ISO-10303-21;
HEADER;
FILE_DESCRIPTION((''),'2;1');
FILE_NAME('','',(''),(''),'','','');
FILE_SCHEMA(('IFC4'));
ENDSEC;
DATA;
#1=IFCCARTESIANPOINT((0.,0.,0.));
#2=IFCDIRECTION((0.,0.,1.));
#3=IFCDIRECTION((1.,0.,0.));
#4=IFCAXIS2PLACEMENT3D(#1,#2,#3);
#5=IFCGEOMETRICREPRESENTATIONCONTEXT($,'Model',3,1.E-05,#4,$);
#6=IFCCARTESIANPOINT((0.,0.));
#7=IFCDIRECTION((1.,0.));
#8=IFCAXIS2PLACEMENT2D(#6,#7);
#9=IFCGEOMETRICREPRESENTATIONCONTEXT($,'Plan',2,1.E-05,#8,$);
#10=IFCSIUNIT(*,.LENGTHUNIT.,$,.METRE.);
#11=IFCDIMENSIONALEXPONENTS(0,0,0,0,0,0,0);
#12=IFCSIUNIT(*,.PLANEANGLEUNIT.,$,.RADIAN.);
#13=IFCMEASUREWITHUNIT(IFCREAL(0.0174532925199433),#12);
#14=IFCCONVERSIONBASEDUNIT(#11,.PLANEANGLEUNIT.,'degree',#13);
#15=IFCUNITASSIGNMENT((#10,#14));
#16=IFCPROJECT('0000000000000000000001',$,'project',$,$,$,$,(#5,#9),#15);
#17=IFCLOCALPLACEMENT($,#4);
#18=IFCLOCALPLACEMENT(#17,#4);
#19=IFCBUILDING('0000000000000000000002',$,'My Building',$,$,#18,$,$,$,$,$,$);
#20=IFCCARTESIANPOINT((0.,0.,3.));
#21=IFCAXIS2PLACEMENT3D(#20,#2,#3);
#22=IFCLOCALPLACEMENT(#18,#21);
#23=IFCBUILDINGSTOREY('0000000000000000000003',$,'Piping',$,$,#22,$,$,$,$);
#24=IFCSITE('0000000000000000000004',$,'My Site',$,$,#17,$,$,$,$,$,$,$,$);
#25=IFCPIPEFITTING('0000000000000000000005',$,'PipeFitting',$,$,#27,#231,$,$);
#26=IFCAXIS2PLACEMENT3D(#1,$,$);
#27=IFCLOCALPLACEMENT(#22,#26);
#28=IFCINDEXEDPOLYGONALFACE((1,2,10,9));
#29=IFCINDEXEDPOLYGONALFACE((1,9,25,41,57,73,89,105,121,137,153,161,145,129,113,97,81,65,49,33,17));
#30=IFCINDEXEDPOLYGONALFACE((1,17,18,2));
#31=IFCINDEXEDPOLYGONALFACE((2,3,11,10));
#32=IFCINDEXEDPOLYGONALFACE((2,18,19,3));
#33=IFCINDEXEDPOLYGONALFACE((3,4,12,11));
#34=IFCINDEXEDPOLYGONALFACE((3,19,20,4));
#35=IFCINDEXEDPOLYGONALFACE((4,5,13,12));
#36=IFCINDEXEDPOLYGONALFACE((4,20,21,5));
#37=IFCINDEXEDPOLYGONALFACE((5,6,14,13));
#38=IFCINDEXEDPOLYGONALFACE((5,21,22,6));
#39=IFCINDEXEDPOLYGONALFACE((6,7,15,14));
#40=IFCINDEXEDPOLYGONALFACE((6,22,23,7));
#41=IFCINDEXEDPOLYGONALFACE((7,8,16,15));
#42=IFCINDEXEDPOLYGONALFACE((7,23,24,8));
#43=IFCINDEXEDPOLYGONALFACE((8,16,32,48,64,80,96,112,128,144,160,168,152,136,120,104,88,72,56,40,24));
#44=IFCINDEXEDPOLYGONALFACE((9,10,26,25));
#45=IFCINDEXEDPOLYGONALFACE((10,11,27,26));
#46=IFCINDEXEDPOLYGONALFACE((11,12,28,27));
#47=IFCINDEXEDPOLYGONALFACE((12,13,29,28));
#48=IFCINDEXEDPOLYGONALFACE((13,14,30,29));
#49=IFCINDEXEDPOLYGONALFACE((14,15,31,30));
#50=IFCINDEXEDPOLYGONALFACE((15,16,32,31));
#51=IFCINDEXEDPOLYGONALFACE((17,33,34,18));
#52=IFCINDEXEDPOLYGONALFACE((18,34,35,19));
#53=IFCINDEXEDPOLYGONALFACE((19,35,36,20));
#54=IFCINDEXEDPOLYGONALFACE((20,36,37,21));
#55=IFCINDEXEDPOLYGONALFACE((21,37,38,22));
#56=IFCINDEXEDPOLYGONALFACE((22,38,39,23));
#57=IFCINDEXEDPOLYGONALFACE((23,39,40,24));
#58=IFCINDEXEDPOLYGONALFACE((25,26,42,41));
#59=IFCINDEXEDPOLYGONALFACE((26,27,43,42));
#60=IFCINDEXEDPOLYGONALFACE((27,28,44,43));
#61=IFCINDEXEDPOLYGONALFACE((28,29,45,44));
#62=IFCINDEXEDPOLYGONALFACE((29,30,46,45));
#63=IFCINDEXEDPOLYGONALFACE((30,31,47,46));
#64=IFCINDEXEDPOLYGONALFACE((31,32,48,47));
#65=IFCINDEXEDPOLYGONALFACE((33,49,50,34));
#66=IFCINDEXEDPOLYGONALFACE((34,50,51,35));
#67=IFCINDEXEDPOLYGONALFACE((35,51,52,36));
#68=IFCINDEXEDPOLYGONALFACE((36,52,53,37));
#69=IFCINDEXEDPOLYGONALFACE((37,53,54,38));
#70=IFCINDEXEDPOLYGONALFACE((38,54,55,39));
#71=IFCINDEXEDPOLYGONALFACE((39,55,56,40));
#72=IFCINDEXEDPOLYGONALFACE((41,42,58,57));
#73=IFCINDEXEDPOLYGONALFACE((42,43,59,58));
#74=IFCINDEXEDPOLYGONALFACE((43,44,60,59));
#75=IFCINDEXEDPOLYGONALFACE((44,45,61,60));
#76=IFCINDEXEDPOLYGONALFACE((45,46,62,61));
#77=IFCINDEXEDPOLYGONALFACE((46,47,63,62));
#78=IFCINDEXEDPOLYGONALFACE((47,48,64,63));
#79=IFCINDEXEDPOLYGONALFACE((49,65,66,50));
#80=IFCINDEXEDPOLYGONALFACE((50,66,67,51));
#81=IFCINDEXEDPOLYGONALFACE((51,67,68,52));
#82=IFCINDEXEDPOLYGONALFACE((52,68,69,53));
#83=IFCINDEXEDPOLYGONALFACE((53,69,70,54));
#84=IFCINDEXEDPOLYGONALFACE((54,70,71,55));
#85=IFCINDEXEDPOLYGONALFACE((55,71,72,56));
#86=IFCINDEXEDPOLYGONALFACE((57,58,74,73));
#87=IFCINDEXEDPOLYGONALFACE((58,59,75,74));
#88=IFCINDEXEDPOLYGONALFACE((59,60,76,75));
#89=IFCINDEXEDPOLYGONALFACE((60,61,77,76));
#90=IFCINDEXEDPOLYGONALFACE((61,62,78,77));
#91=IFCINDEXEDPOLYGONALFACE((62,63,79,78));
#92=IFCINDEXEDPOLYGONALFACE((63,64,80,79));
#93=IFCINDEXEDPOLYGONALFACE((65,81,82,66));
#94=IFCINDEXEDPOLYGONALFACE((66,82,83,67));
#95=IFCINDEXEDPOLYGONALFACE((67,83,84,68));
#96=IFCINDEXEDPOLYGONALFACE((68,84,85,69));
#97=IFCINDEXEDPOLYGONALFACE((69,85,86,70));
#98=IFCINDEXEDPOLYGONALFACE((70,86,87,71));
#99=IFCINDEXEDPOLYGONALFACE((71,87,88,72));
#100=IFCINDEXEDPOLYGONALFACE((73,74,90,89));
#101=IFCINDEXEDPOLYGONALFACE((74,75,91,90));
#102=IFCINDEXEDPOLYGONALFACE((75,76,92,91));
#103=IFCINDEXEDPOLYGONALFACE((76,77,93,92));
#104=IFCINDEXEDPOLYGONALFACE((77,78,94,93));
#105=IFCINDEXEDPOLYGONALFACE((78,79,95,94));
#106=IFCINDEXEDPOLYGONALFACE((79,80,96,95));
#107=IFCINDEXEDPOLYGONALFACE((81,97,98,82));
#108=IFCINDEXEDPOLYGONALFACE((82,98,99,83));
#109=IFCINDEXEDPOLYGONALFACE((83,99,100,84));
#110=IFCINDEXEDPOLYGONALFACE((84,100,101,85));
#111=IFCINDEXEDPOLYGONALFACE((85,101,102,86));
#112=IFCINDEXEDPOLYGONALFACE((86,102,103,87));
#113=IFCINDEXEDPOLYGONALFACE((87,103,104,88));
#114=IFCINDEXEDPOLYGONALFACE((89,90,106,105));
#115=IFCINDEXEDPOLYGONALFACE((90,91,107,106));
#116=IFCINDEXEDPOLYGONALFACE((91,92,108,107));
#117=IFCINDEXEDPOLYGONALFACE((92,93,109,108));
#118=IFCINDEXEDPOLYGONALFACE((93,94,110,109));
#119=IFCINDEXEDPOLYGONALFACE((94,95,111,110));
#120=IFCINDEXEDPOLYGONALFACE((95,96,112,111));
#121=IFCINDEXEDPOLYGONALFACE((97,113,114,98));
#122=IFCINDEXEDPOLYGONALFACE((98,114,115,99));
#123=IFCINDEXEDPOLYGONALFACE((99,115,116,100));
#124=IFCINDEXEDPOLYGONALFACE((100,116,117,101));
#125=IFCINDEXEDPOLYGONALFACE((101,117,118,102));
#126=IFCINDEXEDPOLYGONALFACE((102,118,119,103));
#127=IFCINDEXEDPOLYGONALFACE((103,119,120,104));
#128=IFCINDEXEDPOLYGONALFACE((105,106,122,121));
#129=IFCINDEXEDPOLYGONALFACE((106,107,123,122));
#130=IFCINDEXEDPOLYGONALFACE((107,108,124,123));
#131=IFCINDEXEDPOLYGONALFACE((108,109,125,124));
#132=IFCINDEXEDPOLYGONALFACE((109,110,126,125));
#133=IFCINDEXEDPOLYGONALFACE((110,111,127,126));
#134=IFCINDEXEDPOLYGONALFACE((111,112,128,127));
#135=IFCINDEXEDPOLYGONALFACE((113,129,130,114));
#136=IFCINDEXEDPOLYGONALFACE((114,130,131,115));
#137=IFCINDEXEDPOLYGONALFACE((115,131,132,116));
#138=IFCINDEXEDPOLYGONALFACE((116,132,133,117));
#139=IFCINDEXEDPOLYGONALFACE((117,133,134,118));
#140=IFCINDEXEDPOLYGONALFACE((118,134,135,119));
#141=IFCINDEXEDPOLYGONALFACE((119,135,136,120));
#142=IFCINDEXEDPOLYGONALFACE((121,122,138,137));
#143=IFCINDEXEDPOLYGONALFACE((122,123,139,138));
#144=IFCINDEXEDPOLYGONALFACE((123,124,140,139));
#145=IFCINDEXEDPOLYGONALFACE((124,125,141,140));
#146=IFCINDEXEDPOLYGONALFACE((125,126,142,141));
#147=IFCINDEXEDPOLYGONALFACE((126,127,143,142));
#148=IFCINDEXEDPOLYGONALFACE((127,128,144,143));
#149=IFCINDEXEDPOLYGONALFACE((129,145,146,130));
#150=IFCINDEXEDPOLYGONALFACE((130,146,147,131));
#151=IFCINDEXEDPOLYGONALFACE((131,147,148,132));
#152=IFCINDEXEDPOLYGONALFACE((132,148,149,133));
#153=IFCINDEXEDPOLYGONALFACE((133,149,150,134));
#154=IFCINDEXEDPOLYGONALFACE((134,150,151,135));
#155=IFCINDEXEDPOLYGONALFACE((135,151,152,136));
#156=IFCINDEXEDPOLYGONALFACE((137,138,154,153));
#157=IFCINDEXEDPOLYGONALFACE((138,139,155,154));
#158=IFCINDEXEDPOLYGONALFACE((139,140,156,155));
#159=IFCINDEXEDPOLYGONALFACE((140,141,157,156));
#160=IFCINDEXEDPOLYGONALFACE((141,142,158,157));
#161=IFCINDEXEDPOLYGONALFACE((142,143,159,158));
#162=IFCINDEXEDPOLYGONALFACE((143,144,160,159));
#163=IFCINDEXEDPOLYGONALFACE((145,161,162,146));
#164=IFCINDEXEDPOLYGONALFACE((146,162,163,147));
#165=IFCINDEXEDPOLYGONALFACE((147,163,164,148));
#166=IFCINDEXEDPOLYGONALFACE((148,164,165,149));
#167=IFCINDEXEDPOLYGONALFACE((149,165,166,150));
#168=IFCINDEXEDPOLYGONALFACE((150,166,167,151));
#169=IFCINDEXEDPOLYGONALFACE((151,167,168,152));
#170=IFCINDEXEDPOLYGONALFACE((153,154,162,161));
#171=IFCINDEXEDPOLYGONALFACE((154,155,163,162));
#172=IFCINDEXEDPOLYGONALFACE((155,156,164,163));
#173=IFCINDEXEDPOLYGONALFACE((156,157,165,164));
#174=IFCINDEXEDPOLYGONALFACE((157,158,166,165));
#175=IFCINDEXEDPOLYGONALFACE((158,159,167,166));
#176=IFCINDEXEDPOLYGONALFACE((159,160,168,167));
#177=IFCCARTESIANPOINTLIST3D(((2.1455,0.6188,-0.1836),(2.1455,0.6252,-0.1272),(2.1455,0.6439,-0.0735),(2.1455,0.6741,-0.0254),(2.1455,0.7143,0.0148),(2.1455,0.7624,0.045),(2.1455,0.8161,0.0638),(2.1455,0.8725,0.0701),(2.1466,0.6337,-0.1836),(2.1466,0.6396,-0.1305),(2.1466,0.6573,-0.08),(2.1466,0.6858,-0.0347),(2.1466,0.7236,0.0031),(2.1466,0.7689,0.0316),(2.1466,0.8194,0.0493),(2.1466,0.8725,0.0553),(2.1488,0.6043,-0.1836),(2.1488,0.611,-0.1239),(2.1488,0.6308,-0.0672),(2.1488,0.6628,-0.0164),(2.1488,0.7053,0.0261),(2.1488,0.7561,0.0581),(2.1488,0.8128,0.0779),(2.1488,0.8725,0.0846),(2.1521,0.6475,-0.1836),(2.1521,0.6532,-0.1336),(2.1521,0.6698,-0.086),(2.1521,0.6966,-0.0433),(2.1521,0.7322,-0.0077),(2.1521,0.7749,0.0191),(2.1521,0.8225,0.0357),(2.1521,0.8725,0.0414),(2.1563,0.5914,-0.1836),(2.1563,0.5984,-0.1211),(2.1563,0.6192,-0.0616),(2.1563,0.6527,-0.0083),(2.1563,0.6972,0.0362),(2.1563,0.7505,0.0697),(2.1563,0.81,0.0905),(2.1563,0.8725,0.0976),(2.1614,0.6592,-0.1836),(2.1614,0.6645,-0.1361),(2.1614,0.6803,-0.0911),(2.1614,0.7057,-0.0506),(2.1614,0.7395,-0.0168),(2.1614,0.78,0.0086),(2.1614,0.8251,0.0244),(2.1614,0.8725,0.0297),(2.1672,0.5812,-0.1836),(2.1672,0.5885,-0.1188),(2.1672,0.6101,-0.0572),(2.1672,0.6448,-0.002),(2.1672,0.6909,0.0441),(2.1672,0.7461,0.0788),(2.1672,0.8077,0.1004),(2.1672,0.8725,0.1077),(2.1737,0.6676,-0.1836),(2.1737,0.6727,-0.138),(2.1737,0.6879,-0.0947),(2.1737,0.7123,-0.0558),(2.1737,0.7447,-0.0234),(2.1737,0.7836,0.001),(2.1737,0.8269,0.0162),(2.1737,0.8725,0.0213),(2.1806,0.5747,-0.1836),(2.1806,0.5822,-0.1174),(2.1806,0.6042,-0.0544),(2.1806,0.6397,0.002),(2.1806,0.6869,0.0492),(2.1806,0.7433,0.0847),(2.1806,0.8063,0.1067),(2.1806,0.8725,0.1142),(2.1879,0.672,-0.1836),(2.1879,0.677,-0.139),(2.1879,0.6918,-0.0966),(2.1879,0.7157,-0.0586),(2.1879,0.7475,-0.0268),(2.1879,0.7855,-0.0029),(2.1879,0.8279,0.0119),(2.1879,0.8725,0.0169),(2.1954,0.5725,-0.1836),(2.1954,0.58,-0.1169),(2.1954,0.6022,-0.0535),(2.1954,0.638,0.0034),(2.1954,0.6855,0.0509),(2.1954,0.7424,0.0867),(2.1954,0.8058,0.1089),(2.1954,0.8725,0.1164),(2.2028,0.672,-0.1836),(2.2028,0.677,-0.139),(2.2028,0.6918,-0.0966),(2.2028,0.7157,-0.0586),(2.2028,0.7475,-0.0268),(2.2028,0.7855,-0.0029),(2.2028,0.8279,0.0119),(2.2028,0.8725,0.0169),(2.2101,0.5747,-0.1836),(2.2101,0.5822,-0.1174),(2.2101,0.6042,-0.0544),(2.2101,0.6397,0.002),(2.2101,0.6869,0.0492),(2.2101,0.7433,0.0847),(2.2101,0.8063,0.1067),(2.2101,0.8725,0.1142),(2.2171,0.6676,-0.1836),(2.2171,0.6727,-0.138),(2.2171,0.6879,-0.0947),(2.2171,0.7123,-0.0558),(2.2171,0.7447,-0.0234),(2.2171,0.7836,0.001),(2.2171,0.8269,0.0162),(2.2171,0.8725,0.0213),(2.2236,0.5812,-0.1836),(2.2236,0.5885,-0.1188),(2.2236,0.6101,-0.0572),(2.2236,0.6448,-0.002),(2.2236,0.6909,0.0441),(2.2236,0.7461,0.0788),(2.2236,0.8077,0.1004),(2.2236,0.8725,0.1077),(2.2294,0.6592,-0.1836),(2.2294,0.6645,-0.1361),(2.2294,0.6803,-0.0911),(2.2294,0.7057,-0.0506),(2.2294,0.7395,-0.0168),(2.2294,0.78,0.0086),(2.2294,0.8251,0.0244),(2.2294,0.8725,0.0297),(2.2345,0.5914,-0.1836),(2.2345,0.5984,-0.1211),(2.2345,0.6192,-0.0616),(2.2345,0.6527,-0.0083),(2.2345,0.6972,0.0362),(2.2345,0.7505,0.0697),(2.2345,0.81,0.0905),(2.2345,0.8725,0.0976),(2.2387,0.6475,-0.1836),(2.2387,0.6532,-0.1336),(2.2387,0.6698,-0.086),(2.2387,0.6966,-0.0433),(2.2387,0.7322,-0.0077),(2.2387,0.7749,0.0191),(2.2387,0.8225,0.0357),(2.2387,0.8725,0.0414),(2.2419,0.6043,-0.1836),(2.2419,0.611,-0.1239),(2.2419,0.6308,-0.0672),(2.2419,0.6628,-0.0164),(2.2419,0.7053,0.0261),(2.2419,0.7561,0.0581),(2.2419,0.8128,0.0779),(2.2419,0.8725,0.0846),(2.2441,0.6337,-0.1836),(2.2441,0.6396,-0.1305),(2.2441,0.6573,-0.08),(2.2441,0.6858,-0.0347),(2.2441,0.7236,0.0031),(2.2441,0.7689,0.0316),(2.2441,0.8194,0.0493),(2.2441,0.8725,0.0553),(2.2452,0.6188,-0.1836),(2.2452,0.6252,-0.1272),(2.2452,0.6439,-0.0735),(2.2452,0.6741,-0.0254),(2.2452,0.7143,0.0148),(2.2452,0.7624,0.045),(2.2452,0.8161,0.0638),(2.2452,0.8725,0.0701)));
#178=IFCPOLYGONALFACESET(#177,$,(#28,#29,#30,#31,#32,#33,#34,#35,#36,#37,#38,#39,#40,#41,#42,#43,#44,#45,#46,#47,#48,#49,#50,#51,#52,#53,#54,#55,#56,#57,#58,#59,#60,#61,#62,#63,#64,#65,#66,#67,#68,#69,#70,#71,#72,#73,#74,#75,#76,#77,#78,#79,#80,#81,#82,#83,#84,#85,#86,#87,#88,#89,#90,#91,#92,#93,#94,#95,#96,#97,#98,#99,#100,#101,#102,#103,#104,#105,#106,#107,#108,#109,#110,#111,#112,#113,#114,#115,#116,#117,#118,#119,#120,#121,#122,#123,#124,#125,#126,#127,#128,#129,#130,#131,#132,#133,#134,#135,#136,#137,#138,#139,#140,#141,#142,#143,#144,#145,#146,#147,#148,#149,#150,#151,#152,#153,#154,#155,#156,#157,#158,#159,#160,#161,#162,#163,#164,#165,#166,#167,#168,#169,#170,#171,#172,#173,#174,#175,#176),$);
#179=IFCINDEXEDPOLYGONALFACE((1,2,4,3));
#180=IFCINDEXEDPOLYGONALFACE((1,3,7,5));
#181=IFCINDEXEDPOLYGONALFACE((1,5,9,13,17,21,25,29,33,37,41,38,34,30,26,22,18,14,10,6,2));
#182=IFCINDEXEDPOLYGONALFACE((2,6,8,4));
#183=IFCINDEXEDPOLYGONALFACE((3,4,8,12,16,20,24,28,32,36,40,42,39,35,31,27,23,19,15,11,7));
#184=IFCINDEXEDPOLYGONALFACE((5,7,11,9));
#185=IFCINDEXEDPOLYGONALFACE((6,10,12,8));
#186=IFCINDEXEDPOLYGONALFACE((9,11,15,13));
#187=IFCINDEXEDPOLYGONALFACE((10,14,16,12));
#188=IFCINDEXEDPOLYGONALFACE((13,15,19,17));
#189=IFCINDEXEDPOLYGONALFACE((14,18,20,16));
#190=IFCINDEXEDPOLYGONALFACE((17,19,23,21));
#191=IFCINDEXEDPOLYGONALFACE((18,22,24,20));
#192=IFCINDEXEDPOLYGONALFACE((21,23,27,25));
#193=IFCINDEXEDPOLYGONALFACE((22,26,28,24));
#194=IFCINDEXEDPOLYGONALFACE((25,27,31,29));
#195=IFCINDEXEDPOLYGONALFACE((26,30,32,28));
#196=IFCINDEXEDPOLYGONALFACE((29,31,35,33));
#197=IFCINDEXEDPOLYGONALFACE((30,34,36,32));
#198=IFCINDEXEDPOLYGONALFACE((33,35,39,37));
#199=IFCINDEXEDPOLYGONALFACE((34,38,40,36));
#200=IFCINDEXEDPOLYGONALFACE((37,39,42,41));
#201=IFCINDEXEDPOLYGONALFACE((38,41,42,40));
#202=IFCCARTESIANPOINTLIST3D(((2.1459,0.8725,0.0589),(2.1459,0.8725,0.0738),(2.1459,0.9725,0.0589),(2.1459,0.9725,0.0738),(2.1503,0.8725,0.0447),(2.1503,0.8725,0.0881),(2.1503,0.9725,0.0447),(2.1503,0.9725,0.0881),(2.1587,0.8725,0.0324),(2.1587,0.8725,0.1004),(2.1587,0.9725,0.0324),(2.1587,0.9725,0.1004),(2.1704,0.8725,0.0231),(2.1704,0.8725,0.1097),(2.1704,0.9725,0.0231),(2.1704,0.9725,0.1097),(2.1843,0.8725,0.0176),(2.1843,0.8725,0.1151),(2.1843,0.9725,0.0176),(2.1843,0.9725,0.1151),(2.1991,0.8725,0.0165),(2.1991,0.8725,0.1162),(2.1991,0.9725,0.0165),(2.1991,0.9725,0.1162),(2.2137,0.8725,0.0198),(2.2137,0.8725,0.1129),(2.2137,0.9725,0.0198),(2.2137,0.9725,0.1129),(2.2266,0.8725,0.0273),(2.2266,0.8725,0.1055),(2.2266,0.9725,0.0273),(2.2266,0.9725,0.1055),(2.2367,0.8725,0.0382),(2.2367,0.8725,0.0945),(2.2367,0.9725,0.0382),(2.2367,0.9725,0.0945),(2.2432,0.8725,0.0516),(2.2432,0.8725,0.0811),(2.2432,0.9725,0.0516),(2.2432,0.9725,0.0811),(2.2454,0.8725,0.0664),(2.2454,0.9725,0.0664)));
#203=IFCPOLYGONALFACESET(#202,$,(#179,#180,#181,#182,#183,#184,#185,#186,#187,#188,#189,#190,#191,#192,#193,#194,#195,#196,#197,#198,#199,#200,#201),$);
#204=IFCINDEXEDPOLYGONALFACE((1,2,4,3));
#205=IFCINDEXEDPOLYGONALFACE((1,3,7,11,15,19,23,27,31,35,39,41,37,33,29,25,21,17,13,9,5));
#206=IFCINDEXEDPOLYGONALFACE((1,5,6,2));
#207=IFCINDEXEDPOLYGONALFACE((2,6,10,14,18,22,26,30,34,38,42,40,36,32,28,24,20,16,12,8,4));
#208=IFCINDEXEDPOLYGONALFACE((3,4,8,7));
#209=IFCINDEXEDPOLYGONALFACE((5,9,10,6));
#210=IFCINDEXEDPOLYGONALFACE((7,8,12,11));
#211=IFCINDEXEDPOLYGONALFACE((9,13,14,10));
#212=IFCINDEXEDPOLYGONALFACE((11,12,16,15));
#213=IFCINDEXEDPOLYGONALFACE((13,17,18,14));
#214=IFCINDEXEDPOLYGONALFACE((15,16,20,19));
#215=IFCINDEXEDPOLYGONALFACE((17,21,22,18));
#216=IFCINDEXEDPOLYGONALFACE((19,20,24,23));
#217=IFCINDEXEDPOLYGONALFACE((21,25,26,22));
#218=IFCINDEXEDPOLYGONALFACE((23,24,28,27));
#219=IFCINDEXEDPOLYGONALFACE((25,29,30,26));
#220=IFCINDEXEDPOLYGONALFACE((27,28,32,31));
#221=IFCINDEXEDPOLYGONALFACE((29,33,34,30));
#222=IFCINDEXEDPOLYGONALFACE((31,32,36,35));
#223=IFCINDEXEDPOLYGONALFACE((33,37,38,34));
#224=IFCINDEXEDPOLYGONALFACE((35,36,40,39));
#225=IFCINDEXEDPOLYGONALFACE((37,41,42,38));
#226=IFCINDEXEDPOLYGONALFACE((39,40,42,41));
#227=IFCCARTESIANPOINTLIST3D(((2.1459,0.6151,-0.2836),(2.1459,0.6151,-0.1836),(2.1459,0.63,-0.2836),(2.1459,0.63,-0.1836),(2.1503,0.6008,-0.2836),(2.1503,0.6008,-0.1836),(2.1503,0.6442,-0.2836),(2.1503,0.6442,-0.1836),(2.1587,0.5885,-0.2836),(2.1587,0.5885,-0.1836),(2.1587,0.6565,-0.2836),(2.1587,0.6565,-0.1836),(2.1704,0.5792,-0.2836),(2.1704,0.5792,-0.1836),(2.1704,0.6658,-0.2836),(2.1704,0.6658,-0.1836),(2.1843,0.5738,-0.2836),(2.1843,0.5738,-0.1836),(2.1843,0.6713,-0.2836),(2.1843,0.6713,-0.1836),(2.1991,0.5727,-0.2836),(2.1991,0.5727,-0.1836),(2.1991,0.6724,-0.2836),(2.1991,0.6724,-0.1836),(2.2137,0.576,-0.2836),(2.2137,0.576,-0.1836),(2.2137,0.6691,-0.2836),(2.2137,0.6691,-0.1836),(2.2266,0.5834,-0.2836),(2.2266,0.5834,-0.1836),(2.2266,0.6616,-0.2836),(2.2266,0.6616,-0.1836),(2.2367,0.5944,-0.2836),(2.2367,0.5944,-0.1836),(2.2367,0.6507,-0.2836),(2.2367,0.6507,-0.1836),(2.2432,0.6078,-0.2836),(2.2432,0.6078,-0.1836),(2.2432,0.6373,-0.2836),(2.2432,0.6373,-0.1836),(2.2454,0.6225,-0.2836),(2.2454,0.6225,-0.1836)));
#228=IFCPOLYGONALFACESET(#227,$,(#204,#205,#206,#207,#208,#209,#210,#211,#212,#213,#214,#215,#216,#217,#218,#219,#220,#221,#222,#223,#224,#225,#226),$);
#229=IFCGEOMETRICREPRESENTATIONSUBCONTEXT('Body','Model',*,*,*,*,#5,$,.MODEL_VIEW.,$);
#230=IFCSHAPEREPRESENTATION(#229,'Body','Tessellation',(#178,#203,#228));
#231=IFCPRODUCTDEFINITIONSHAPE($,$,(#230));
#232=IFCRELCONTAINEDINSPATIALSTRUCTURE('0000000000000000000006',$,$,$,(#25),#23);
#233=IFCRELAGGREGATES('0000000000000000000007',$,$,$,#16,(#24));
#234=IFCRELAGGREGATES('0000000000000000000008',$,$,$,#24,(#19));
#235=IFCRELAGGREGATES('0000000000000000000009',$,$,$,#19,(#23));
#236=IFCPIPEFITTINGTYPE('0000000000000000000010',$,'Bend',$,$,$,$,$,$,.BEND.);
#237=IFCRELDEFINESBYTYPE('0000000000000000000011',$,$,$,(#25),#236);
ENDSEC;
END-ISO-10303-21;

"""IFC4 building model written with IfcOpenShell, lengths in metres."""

from ifc_helpers import new_model, entity, si_unit, converted_unit, frame, origin_with_axes, origin_2d_with_axis, place, context, subcontext, project, spatial, circle, extrude, source, transform, mapped, type_object, type_shapes, element, save


model = new_model("IFC4")

# Units and contexts
model_context = context("Model", 3, precision=1e-05, world=origin_with_axes())
plan_context = context("Plan", 2, precision=1e-05, world=origin_2d_with_axis())
body_context = subcontext(model_context, "Body", "Model", "MODEL_VIEW")
ifc_project = project(units=[si_unit("LENGTHUNIT", "METRE"), converted_unit("PLANEANGLEUNIT", "degree", entity("IfcReal", 0.0174532925199433), si_unit("PLANEANGLEUNIT", "RADIAN"), dimensions=[0, 0, 0, 0, 0, 0, 0])], contexts=[model_context, plan_context])

# Site, building, storey
site_placement = place(None, origin_with_axes())
site = spatial("IfcSite", under=ifc_project, at=site_placement, Name="My Site")
building_placement = place(site_placement, origin_with_axes())
building = spatial("IfcBuilding", under=site, at=building_placement, Name="My Building")
storey_placement = place(building_placement, frame((0.0, 0.0, 3.0), z_axis=(0.0, 0.0, 1.0), x_axis=(1.0, 0.0, 0.0)))
storey = spatial("IfcBuildingStorey", under=building, at=storey_placement, Name="Piping")

# Pipe fitting
pipe_fitting_type_1 = type_object("IfcPipeFittingType", Name="Bend", PredefinedType="BEND")
shared_shape = source(origin_with_axes(), body_context, "Body", "SolidModel", [
    entity("IfcSweptDiskSolid", entity("IfcIndexedPolyCurve", entity("IfcCartesianPointList3D", [[0.0, 0.0, 0.1], [0.0, -0.0732, 0.2768], [0.0, -0.25, 0.35]]), [entity("IfcArcIndex", [1, 2, 3])]), 0.05),
    extrude(circle(Radius=0.05), origin_with_axes(), (0.0, 0.0, 1.0), 0.1),
    extrude(circle(Radius=0.05), frame((0.0, -0.25, 0.35), z_axis=(0.0, -1.0, -0.000002), x_axis=(1.0, 0.0, 0.0)), (0.0, 0.0, 1.0), 0.1),
])
type_shapes(pipe_fitting_type_1, [shared_shape])
for number, where, z_axis, x_axis, name in (
    (1, (2.1954, 0.9725, 0.0664), (0.0, -1.0, 0.000002), (1.0, 0.0, 0.0), "PipeFitting"),
):
    element("IfcPipeFitting", number, at=place(storey_placement, frame(where, z_axis=z_axis, x_axis=x_axis)), inside=storey, type_object=pipe_fitting_type_1, Name=name, context=body_context, shape_type="MappedRepresentation", body=[
        mapped(shared_shape, transform((0.0, 0.0, 0.0), x_axis=(1.0, 0.0, 0.0), y_axis=(0.0, 1.0, 0.0), z_axis=(0.0, 0.0, 1.0), scale=1.0)),
    ])

save(model, "model.ifc")
